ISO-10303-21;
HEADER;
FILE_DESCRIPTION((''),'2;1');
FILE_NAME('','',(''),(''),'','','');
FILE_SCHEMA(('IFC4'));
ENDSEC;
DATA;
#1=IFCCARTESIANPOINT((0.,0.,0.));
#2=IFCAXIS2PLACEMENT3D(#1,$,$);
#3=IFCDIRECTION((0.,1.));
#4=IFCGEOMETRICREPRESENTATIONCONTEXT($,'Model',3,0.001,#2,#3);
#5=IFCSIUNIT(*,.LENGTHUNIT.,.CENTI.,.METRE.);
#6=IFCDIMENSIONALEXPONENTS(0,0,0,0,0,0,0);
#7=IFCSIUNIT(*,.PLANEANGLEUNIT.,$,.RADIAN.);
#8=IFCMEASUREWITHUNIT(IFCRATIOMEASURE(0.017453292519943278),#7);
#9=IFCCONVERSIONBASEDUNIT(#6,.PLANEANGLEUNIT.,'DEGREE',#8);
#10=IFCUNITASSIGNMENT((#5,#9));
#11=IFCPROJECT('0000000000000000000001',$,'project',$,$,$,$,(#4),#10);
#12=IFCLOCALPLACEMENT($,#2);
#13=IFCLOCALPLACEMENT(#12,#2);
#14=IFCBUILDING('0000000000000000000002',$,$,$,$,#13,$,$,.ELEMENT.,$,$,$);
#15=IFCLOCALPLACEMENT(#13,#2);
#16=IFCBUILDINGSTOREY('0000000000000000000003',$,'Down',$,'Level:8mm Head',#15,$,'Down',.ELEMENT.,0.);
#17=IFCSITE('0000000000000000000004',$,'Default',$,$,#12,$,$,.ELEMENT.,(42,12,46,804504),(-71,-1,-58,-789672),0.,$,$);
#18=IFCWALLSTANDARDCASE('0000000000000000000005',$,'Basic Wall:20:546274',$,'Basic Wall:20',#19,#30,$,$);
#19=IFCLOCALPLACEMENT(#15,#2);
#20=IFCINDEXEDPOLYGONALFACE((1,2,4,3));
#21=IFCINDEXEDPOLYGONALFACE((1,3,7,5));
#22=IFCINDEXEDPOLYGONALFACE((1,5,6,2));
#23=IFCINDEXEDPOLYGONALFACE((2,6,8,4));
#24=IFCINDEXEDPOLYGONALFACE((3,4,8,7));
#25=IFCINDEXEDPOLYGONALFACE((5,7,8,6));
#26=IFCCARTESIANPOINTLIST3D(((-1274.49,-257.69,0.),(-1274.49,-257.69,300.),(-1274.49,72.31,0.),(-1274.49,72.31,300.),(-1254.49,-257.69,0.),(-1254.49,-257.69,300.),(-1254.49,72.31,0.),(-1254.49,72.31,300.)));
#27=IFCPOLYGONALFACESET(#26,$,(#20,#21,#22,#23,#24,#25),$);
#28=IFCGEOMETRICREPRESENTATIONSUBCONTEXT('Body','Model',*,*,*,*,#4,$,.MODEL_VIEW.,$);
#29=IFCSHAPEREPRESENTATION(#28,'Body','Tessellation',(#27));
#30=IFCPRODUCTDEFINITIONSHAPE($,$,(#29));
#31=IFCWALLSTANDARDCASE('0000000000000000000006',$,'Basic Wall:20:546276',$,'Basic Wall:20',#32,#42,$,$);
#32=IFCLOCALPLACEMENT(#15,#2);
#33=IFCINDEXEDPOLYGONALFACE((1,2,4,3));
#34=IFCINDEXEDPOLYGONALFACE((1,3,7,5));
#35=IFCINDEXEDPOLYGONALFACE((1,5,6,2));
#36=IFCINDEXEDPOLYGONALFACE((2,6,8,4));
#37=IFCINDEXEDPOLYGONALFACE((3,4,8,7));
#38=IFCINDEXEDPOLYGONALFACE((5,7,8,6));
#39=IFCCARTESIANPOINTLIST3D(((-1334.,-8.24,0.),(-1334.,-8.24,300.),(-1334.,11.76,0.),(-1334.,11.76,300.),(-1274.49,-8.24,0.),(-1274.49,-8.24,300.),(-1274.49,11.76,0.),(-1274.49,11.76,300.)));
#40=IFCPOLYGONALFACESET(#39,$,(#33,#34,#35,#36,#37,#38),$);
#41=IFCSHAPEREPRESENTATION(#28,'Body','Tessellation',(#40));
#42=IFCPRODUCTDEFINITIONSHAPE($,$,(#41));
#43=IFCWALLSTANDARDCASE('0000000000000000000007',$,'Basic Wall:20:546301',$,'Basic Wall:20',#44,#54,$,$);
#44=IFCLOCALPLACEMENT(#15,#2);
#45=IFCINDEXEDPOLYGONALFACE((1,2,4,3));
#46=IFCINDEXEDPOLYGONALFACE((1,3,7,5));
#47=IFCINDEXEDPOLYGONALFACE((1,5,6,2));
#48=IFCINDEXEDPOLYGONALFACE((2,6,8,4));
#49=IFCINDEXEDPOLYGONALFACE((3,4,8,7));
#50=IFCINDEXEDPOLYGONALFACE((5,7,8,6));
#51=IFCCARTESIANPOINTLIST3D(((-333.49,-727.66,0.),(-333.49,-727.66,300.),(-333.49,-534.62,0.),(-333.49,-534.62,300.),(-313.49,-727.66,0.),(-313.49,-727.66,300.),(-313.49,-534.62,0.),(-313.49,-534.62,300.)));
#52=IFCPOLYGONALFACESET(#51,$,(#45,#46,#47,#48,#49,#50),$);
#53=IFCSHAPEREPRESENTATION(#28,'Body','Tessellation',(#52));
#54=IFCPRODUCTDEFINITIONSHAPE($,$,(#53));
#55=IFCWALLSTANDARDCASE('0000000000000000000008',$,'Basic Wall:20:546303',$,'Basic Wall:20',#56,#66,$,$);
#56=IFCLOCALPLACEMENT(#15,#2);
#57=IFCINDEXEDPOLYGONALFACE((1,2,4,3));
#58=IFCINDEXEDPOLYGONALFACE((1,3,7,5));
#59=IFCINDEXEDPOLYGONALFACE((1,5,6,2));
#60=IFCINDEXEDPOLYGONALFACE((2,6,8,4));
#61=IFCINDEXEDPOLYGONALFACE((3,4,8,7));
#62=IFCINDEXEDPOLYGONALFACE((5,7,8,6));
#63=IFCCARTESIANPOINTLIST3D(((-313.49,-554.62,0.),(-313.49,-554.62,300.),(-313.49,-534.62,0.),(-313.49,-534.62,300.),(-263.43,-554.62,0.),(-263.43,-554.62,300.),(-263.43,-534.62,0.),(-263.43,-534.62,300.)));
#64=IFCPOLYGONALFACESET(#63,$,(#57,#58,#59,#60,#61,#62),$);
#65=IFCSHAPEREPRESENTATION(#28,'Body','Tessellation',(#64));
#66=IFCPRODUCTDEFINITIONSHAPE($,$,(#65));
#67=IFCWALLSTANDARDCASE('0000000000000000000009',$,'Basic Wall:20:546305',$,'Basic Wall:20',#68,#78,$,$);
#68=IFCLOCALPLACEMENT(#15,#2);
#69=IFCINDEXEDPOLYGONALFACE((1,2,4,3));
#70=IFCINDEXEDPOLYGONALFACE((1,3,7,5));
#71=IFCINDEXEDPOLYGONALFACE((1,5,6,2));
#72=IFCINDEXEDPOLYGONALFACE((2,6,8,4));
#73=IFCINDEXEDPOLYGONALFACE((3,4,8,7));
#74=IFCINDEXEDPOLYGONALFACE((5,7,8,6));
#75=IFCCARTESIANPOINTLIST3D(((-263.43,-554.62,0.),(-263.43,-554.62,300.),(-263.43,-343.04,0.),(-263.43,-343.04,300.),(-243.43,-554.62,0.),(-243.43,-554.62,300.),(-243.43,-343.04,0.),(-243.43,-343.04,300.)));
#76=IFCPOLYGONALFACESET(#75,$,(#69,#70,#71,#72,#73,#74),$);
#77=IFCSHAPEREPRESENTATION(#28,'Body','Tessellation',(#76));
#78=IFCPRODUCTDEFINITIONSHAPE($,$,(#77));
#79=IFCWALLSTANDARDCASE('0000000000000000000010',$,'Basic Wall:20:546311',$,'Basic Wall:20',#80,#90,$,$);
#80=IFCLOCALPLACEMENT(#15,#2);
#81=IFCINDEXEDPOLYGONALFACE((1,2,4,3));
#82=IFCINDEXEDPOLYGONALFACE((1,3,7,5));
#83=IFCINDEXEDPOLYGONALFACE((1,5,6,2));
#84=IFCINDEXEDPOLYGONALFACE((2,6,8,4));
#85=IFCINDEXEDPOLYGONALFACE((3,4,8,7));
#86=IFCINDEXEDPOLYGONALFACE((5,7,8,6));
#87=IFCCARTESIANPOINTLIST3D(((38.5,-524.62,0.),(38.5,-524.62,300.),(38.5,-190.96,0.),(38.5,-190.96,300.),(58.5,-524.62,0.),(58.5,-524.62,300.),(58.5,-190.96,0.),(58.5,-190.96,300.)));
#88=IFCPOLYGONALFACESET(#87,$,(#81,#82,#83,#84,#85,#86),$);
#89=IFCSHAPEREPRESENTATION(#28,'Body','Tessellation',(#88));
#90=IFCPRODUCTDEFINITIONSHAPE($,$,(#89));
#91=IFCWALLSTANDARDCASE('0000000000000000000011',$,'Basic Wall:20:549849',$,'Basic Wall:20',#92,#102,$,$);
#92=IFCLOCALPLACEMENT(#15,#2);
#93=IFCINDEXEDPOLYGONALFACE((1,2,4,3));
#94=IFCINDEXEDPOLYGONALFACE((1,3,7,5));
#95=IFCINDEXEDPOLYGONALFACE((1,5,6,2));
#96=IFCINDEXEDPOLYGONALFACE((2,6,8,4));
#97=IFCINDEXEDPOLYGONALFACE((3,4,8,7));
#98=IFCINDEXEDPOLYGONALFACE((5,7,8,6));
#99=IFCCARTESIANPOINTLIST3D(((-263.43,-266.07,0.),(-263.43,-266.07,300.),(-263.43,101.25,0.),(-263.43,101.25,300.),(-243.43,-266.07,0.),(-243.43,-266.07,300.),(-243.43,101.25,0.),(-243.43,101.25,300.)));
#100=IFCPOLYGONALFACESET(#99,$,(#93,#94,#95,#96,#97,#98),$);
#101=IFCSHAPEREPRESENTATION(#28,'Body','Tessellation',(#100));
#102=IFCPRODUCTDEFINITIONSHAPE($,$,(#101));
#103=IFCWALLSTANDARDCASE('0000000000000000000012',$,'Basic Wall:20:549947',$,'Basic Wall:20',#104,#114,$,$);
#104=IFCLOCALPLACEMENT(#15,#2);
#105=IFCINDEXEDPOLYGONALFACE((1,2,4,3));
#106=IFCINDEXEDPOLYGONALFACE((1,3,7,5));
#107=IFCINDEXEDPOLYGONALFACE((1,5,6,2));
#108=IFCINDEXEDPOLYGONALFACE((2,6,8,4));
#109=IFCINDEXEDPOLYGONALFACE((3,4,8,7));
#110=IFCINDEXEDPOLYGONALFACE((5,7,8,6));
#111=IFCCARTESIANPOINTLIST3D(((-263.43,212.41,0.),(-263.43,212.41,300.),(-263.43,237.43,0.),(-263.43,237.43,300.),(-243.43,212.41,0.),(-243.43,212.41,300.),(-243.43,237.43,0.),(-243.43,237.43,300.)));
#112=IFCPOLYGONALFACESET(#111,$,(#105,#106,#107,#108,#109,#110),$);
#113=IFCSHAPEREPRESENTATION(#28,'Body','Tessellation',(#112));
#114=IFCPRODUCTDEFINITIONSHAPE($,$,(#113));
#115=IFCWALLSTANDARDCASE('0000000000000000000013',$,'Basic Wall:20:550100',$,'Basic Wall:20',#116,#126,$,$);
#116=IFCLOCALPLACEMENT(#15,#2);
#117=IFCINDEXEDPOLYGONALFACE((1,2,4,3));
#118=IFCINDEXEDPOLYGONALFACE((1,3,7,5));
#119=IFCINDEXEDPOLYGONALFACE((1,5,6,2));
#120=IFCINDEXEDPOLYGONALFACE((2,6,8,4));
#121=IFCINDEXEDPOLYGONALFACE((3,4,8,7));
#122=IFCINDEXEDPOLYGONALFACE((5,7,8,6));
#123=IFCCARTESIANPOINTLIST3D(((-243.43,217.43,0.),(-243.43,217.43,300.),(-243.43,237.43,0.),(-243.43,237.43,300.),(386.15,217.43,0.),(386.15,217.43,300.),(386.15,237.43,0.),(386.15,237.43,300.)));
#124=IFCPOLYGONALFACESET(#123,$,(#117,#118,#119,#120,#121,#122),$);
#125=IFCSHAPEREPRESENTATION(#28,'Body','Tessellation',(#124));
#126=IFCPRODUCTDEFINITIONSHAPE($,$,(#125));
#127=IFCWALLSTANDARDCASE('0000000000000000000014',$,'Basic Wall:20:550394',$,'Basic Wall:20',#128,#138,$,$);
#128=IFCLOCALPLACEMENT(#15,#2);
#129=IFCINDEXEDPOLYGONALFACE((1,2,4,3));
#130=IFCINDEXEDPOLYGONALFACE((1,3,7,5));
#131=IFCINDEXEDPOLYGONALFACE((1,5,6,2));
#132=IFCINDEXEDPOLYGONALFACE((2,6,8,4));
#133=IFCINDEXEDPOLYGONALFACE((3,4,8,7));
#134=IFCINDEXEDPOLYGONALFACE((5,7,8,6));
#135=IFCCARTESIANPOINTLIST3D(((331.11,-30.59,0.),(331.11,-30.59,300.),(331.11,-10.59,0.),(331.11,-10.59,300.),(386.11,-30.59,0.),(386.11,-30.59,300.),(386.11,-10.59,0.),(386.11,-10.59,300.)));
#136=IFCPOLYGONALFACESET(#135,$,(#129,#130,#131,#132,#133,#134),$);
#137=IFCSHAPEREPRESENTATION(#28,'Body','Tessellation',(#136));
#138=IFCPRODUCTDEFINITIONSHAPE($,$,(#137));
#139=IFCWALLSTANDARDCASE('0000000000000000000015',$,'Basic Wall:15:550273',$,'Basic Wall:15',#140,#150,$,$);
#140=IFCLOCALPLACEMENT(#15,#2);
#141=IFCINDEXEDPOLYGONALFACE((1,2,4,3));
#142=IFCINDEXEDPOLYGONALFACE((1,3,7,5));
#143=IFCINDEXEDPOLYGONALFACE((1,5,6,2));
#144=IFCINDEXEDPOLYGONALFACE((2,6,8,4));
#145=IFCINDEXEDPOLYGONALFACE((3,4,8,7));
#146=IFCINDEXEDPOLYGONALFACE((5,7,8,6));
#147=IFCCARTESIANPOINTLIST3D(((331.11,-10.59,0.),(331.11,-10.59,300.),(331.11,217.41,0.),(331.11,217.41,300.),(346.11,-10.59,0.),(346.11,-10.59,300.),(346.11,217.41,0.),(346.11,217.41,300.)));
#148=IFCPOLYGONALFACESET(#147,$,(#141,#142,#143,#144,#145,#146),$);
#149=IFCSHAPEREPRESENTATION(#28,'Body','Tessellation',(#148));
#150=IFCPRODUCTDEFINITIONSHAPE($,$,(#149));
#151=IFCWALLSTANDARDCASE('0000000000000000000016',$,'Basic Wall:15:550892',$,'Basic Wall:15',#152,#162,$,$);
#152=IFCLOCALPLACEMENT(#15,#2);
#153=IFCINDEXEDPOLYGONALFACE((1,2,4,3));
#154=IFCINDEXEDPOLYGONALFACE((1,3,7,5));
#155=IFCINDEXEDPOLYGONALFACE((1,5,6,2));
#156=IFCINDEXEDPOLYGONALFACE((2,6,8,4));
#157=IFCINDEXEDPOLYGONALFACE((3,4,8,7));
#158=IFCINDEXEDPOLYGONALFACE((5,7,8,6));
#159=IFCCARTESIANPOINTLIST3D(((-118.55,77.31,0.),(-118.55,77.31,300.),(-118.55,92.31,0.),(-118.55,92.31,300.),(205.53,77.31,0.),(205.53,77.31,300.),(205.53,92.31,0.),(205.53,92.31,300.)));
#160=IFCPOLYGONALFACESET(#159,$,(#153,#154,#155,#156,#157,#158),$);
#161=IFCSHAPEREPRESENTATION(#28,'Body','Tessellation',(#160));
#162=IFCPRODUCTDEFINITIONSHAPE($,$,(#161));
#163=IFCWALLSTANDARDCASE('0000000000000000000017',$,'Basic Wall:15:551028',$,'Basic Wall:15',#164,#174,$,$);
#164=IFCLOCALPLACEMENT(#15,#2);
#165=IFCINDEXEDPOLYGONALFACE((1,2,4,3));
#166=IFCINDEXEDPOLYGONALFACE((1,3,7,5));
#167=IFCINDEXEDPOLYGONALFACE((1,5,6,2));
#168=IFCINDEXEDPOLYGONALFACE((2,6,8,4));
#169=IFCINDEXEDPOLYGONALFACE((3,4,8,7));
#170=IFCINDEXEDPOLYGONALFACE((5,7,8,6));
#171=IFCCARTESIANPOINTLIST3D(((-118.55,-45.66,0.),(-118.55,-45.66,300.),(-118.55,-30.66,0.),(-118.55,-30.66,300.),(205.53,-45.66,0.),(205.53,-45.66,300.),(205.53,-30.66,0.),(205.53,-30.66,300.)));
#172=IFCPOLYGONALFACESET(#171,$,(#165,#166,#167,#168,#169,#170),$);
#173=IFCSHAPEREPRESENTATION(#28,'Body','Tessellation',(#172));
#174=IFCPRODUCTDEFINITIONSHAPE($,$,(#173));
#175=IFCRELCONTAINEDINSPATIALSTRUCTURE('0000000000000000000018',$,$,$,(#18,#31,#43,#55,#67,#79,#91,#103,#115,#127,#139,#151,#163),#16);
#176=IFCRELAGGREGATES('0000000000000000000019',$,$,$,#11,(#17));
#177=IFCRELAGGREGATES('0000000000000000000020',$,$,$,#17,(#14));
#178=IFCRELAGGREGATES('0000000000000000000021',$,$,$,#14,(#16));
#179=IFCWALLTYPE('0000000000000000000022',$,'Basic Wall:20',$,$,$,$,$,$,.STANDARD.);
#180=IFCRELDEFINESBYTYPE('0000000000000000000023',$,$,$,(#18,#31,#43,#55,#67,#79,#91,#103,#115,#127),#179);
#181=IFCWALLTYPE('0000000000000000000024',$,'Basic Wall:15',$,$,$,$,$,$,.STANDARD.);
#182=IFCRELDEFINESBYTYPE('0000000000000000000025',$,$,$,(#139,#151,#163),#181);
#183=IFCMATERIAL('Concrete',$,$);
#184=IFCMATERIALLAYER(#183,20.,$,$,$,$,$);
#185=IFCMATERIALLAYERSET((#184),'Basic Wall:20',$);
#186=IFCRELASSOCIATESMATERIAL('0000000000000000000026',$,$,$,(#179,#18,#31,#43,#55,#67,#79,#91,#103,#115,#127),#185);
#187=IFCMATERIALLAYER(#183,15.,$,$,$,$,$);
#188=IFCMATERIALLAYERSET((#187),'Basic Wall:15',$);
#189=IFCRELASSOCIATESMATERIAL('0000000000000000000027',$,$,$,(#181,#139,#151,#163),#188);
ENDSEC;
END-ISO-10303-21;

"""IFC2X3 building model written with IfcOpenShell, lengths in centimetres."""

from ifc_helpers import new_model, entity, si_unit, converted_unit, direction, frame, frame_2d, origin, place, context, subcontext, project, spatial, rectangle, extrude, material, layer, layer_set, layer_usage, type_object, element, save


model = new_model("IFC2X3")

# Units and contexts
model_context = context("Model", 3, precision=0.001, world=origin(), true_north=direction((0.0, 1.0)))
body_context = subcontext(model_context, "Body", "Model", "MODEL_VIEW")
ifc_project = project(units=[si_unit("LENGTHUNIT", "METRE", prefix="CENTI"), converted_unit("PLANEANGLEUNIT", "DEGREE", entity("IfcRatioMeasure", 0.017453292519943278), si_unit("PLANEANGLEUNIT", "RADIAN"), dimensions=[0, 0, 0, 0, 0, 0, 0])], contexts=[model_context])

# Site, building, storey
site_placement = place(None, origin())
site = spatial("IfcSite", under=ifc_project, at=site_placement, Name="Default", CompositionType="ELEMENT", RefLatitude=(42, 12, 46, 804504), RefLongitude=(-71, -1, -58, -789672), RefElevation=0.0)
building_placement = place(site_placement, origin())
building = spatial("IfcBuilding", under=site, at=building_placement, CompositionType="ELEMENT")
storey_placement = place(building_placement, origin())
storey = spatial("IfcBuildingStorey", under=building, at=storey_placement, Name="Down", ObjectType="Level:8mm Head", LongName="Down", CompositionType="ELEMENT", Elevation=0.0)

# Shared definitions
ifc_material = material(Name="Concrete")

# Walls
ifc_layer_1 = layer(ifc_material, 20.0)
ifc_layer_set_1 = layer_set([ifc_layer_1], Name="Basic Wall:20")
wall_type_1 = type_object("IfcWallType", Name="Basic Wall:20", PredefinedType="STANDARD", material=ifc_layer_set_1)
ifc_layer_usage_1 = layer_usage(ifc_layer_set_1, "AXIS2", "POSITIVE", -10.0)
wall_1_placement = place(storey_placement, frame((-1264.49, -257.69, 0.0), z_axis=(0.0, 0.0, 1.0), x_axis=(0.0, 1.0, 0.0)))
element("IfcWallStandardCase", 1, at=wall_1_placement, inside=storey, type_object=wall_type_1, material=ifc_layer_usage_1, Name="Basic Wall:20:546274", ObjectType="Basic Wall:20", context=body_context, shape_type="SweptSolid", body=[
    extrude(rectangle(XDim=330.0, YDim=20.0, at=frame_2d((165.0, 0.0), x_axis=(-1.0, 0.0))), origin(), (0.0, 0.0, 1.0), 300.0),
])
ifc_layer_usage_2 = layer_usage(ifc_layer_set_1, "AXIS2", "NEGATIVE", 10.0)
wall_2_placement = place(storey_placement, frame((-1274.49, 1.76, 0.0), z_axis=(0.0, 0.0, 1.0), x_axis=(-1.0, 0.0, 0.0)))
element("IfcWallStandardCase", 2, at=wall_2_placement, inside=storey, type_object=wall_type_1, material=ifc_layer_usage_2, Name="Basic Wall:20:546276", ObjectType="Basic Wall:20", context=body_context, shape_type="SweptSolid", body=[
    extrude(rectangle(XDim=59.52, YDim=20.0, at=frame_2d((29.76, 0.0), x_axis=(-1.0, 0.0))), origin(), (0.0, 0.0, 1.0), 300.0),
])
ifc_layer_usage_3 = layer_usage(ifc_layer_set_1, "AXIS2", "POSITIVE", -10.0)
wall_3_placement = place(storey_placement, frame((-323.49, -534.62, 0.0), z_axis=(0.0, 0.0, 1.0), x_axis=(0.0, -1.0, 0.0)))
element("IfcWallStandardCase", 3, at=wall_3_placement, inside=storey, type_object=wall_type_1, material=ifc_layer_usage_3, Name="Basic Wall:20:546301", ObjectType="Basic Wall:20", context=body_context, shape_type="SweptSolid", body=[
    extrude(rectangle(XDim=193.03, YDim=20.0, at=frame_2d((96.52, 0.0), x_axis=(-1.0, 0.0))), origin(), (0.0, 0.0, 1.0), 300.0),
])
ifc_layer_usage_4 = layer_usage(ifc_layer_set_1, "AXIS2", "NEGATIVE", 10.0)
wall_4_placement = place(storey_placement, frame((-313.49, -544.62, 0.0)))
element("IfcWallStandardCase", 4, at=wall_4_placement, inside=storey, type_object=wall_type_1, material=ifc_layer_usage_4, Name="Basic Wall:20:546303", ObjectType="Basic Wall:20", context=body_context, shape_type="SweptSolid", body=[
    extrude(rectangle(XDim=50.06, YDim=20.0, at=frame_2d((25.03, 0.0), x_axis=(-1.0, 0.0))), origin(), (0.0, 0.0, 1.0), 300.0),
])
ifc_layer_usage_5 = layer_usage(ifc_layer_set_1, "AXIS2", "POSITIVE", -10.0)
wall_5_placement = place(storey_placement, frame((-253.43, -343.04, 0.0), z_axis=(0.0, 0.0, 1.0), x_axis=(0.0, -1.0, 0.0)))
element("IfcWallStandardCase", 5, at=wall_5_placement, inside=storey, type_object=wall_type_1, material=ifc_layer_usage_5, Name="Basic Wall:20:546305", ObjectType="Basic Wall:20", context=body_context, shape_type="SweptSolid", body=[
    extrude(rectangle(XDim=211.59, YDim=20.0, at=frame_2d((105.79, 0.0), x_axis=(-1.0, 0.0))), origin(), (0.0, 0.0, 1.0), 300.0),
])
ifc_layer_usage_6 = layer_usage(ifc_layer_set_1, "AXIS2", "POSITIVE", -10.0)
wall_6_placement = place(storey_placement, frame((48.5, -524.62, 0.0), z_axis=(0.0, 0.0, 1.0), x_axis=(0.0, 1.0, 0.0)))
element("IfcWallStandardCase", 6, at=wall_6_placement, inside=storey, type_object=wall_type_1, material=ifc_layer_usage_6, Name="Basic Wall:20:546311", ObjectType="Basic Wall:20", context=body_context, shape_type="SweptSolid", body=[
    extrude(rectangle(XDim=333.67, YDim=20.0, at=frame_2d((166.83, 0.0), x_axis=(-1.0, 0.0))), origin(), (0.0, 0.0, 1.0), 300.0),
])
ifc_layer_usage_7 = layer_usage(ifc_layer_set_1, "AXIS2", "NEGATIVE", 10.0)
wall_7_placement = place(storey_placement, frame((-253.43, -266.07, 0.0), z_axis=(0.0, 0.0, 1.0), x_axis=(0.0, 1.0, 0.0)))
element("IfcWallStandardCase", 7, at=wall_7_placement, inside=storey, type_object=wall_type_1, material=ifc_layer_usage_7, Name="Basic Wall:20:549849", ObjectType="Basic Wall:20", context=body_context, shape_type="SweptSolid", body=[
    extrude(rectangle(XDim=367.32, YDim=20.0, at=frame_2d((183.66, 0.0), x_axis=(-1.0, 0.0))), origin(), (0.0, 0.0, 1.0), 300.0),
])
ifc_layer_usage_8 = layer_usage(ifc_layer_set_1, "AXIS2", "NEGATIVE", 10.0)
wall_8_placement = place(storey_placement, frame((-253.43, 212.41, 0.0), z_axis=(0.0, 0.0, 1.0), x_axis=(0.0, 1.0, 0.0)))
element("IfcWallStandardCase", 8, at=wall_8_placement, inside=storey, type_object=wall_type_1, material=ifc_layer_usage_8, Name="Basic Wall:20:549947", ObjectType="Basic Wall:20", context=body_context, shape_type="SweptSolid", body=[
    extrude(rectangle(XDim=25.02, YDim=20.0, at=frame_2d((12.51, 0.0), x_axis=(-1.0, 0.0))), origin(), (0.0, 0.0, 1.0), 300.0),
])
ifc_layer_usage_9 = layer_usage(ifc_layer_set_1, "AXIS2", "NEGATIVE", 10.0)
wall_9_placement = place(storey_placement, frame((-243.43, 227.43, 0.0)))
element("IfcWallStandardCase", 9, at=wall_9_placement, inside=storey, type_object=wall_type_1, material=ifc_layer_usage_9, Name="Basic Wall:20:550100", ObjectType="Basic Wall:20", context=body_context, shape_type="SweptSolid", body=[
    extrude(rectangle(XDim=629.58, YDim=20.0, at=frame_2d((314.79, 0.0), x_axis=(-1.0, 0.0))), origin(), (0.0, 0.0, 1.0), 300.0),
])
ifc_layer_usage_10 = layer_usage(ifc_layer_set_1, "AXIS2", "POSITIVE", -10.0)
wall_10_placement = place(storey_placement, frame((331.11, -20.59, 0.0)))
element("IfcWallStandardCase", 10, at=wall_10_placement, inside=storey, type_object=wall_type_1, material=ifc_layer_usage_10, Name="Basic Wall:20:550394", ObjectType="Basic Wall:20", context=body_context, shape_type="SweptSolid", body=[
    extrude(rectangle(XDim=55.0, YDim=20.0, at=frame_2d((27.5, 0.0), x_axis=(-1.0, 0.0))), origin(), (0.0, 0.0, 1.0), 300.0),
])
ifc_layer_2 = layer(ifc_material, 15.0)
ifc_layer_set_2 = layer_set([ifc_layer_2], Name="Basic Wall:15")
ifc_layer_usage_11 = layer_usage(ifc_layer_set_2, "AXIS2", "POSITIVE", -7.5)
wall_type_2 = type_object("IfcWallType", Name="Basic Wall:15", PredefinedType="STANDARD", material=ifc_layer_set_2)
wall_11_placement = place(storey_placement, frame((338.61, 217.41, 0.0), z_axis=(0.0, 0.0, 1.0), x_axis=(0.0, -1.0, 0.0)))
element("IfcWallStandardCase", 11, at=wall_11_placement, inside=storey, type_object=wall_type_2, material=ifc_layer_usage_11, Name="Basic Wall:15:550273", ObjectType="Basic Wall:15", context=body_context, shape_type="SweptSolid", body=[
    extrude(rectangle(XDim=228.0, YDim=15.0, at=frame_2d((114.0, 0.0), x_axis=(-1.0, 0.0))), origin(), (0.0, 0.0, 1.0), 300.0),
])
ifc_layer_usage_12 = layer_usage(ifc_layer_set_2, "AXIS2", "NEGATIVE", 7.5)
wall_12_placement = place(storey_placement, frame((-118.55, 84.81, 0.0)))
element("IfcWallStandardCase", 12, at=wall_12_placement, inside=storey, type_object=wall_type_2, material=ifc_layer_usage_12, Name="Basic Wall:15:550892", ObjectType="Basic Wall:15", context=body_context, shape_type="SweptSolid", body=[
    extrude(rectangle(XDim=324.08, YDim=15.0, at=frame_2d((162.04, 0.0), x_axis=(-1.0, 0.0))), origin(), (0.0, 0.0, 1.0), 300.0),
])
ifc_layer_usage_13 = layer_usage(ifc_layer_set_2, "AXIS2", "NEGATIVE", 7.5)
wall_13_placement = place(storey_placement, frame((205.53, -38.16, 0.0), z_axis=(0.0, 0.0, 1.0), x_axis=(-1.0, 0.0, 0.0)))
element("IfcWallStandardCase", 13, at=wall_13_placement, inside=storey, type_object=wall_type_2, material=ifc_layer_usage_13, Name="Basic Wall:15:551028", ObjectType="Basic Wall:15", context=body_context, shape_type="SweptSolid", body=[
    extrude(rectangle(XDim=324.08, YDim=15.0, at=frame_2d((162.04, 0.0), x_axis=(-1.0, 0.0))), origin(), (0.0, 0.0, 1.0), 300.0),
])

save(model, "model.ifc")
